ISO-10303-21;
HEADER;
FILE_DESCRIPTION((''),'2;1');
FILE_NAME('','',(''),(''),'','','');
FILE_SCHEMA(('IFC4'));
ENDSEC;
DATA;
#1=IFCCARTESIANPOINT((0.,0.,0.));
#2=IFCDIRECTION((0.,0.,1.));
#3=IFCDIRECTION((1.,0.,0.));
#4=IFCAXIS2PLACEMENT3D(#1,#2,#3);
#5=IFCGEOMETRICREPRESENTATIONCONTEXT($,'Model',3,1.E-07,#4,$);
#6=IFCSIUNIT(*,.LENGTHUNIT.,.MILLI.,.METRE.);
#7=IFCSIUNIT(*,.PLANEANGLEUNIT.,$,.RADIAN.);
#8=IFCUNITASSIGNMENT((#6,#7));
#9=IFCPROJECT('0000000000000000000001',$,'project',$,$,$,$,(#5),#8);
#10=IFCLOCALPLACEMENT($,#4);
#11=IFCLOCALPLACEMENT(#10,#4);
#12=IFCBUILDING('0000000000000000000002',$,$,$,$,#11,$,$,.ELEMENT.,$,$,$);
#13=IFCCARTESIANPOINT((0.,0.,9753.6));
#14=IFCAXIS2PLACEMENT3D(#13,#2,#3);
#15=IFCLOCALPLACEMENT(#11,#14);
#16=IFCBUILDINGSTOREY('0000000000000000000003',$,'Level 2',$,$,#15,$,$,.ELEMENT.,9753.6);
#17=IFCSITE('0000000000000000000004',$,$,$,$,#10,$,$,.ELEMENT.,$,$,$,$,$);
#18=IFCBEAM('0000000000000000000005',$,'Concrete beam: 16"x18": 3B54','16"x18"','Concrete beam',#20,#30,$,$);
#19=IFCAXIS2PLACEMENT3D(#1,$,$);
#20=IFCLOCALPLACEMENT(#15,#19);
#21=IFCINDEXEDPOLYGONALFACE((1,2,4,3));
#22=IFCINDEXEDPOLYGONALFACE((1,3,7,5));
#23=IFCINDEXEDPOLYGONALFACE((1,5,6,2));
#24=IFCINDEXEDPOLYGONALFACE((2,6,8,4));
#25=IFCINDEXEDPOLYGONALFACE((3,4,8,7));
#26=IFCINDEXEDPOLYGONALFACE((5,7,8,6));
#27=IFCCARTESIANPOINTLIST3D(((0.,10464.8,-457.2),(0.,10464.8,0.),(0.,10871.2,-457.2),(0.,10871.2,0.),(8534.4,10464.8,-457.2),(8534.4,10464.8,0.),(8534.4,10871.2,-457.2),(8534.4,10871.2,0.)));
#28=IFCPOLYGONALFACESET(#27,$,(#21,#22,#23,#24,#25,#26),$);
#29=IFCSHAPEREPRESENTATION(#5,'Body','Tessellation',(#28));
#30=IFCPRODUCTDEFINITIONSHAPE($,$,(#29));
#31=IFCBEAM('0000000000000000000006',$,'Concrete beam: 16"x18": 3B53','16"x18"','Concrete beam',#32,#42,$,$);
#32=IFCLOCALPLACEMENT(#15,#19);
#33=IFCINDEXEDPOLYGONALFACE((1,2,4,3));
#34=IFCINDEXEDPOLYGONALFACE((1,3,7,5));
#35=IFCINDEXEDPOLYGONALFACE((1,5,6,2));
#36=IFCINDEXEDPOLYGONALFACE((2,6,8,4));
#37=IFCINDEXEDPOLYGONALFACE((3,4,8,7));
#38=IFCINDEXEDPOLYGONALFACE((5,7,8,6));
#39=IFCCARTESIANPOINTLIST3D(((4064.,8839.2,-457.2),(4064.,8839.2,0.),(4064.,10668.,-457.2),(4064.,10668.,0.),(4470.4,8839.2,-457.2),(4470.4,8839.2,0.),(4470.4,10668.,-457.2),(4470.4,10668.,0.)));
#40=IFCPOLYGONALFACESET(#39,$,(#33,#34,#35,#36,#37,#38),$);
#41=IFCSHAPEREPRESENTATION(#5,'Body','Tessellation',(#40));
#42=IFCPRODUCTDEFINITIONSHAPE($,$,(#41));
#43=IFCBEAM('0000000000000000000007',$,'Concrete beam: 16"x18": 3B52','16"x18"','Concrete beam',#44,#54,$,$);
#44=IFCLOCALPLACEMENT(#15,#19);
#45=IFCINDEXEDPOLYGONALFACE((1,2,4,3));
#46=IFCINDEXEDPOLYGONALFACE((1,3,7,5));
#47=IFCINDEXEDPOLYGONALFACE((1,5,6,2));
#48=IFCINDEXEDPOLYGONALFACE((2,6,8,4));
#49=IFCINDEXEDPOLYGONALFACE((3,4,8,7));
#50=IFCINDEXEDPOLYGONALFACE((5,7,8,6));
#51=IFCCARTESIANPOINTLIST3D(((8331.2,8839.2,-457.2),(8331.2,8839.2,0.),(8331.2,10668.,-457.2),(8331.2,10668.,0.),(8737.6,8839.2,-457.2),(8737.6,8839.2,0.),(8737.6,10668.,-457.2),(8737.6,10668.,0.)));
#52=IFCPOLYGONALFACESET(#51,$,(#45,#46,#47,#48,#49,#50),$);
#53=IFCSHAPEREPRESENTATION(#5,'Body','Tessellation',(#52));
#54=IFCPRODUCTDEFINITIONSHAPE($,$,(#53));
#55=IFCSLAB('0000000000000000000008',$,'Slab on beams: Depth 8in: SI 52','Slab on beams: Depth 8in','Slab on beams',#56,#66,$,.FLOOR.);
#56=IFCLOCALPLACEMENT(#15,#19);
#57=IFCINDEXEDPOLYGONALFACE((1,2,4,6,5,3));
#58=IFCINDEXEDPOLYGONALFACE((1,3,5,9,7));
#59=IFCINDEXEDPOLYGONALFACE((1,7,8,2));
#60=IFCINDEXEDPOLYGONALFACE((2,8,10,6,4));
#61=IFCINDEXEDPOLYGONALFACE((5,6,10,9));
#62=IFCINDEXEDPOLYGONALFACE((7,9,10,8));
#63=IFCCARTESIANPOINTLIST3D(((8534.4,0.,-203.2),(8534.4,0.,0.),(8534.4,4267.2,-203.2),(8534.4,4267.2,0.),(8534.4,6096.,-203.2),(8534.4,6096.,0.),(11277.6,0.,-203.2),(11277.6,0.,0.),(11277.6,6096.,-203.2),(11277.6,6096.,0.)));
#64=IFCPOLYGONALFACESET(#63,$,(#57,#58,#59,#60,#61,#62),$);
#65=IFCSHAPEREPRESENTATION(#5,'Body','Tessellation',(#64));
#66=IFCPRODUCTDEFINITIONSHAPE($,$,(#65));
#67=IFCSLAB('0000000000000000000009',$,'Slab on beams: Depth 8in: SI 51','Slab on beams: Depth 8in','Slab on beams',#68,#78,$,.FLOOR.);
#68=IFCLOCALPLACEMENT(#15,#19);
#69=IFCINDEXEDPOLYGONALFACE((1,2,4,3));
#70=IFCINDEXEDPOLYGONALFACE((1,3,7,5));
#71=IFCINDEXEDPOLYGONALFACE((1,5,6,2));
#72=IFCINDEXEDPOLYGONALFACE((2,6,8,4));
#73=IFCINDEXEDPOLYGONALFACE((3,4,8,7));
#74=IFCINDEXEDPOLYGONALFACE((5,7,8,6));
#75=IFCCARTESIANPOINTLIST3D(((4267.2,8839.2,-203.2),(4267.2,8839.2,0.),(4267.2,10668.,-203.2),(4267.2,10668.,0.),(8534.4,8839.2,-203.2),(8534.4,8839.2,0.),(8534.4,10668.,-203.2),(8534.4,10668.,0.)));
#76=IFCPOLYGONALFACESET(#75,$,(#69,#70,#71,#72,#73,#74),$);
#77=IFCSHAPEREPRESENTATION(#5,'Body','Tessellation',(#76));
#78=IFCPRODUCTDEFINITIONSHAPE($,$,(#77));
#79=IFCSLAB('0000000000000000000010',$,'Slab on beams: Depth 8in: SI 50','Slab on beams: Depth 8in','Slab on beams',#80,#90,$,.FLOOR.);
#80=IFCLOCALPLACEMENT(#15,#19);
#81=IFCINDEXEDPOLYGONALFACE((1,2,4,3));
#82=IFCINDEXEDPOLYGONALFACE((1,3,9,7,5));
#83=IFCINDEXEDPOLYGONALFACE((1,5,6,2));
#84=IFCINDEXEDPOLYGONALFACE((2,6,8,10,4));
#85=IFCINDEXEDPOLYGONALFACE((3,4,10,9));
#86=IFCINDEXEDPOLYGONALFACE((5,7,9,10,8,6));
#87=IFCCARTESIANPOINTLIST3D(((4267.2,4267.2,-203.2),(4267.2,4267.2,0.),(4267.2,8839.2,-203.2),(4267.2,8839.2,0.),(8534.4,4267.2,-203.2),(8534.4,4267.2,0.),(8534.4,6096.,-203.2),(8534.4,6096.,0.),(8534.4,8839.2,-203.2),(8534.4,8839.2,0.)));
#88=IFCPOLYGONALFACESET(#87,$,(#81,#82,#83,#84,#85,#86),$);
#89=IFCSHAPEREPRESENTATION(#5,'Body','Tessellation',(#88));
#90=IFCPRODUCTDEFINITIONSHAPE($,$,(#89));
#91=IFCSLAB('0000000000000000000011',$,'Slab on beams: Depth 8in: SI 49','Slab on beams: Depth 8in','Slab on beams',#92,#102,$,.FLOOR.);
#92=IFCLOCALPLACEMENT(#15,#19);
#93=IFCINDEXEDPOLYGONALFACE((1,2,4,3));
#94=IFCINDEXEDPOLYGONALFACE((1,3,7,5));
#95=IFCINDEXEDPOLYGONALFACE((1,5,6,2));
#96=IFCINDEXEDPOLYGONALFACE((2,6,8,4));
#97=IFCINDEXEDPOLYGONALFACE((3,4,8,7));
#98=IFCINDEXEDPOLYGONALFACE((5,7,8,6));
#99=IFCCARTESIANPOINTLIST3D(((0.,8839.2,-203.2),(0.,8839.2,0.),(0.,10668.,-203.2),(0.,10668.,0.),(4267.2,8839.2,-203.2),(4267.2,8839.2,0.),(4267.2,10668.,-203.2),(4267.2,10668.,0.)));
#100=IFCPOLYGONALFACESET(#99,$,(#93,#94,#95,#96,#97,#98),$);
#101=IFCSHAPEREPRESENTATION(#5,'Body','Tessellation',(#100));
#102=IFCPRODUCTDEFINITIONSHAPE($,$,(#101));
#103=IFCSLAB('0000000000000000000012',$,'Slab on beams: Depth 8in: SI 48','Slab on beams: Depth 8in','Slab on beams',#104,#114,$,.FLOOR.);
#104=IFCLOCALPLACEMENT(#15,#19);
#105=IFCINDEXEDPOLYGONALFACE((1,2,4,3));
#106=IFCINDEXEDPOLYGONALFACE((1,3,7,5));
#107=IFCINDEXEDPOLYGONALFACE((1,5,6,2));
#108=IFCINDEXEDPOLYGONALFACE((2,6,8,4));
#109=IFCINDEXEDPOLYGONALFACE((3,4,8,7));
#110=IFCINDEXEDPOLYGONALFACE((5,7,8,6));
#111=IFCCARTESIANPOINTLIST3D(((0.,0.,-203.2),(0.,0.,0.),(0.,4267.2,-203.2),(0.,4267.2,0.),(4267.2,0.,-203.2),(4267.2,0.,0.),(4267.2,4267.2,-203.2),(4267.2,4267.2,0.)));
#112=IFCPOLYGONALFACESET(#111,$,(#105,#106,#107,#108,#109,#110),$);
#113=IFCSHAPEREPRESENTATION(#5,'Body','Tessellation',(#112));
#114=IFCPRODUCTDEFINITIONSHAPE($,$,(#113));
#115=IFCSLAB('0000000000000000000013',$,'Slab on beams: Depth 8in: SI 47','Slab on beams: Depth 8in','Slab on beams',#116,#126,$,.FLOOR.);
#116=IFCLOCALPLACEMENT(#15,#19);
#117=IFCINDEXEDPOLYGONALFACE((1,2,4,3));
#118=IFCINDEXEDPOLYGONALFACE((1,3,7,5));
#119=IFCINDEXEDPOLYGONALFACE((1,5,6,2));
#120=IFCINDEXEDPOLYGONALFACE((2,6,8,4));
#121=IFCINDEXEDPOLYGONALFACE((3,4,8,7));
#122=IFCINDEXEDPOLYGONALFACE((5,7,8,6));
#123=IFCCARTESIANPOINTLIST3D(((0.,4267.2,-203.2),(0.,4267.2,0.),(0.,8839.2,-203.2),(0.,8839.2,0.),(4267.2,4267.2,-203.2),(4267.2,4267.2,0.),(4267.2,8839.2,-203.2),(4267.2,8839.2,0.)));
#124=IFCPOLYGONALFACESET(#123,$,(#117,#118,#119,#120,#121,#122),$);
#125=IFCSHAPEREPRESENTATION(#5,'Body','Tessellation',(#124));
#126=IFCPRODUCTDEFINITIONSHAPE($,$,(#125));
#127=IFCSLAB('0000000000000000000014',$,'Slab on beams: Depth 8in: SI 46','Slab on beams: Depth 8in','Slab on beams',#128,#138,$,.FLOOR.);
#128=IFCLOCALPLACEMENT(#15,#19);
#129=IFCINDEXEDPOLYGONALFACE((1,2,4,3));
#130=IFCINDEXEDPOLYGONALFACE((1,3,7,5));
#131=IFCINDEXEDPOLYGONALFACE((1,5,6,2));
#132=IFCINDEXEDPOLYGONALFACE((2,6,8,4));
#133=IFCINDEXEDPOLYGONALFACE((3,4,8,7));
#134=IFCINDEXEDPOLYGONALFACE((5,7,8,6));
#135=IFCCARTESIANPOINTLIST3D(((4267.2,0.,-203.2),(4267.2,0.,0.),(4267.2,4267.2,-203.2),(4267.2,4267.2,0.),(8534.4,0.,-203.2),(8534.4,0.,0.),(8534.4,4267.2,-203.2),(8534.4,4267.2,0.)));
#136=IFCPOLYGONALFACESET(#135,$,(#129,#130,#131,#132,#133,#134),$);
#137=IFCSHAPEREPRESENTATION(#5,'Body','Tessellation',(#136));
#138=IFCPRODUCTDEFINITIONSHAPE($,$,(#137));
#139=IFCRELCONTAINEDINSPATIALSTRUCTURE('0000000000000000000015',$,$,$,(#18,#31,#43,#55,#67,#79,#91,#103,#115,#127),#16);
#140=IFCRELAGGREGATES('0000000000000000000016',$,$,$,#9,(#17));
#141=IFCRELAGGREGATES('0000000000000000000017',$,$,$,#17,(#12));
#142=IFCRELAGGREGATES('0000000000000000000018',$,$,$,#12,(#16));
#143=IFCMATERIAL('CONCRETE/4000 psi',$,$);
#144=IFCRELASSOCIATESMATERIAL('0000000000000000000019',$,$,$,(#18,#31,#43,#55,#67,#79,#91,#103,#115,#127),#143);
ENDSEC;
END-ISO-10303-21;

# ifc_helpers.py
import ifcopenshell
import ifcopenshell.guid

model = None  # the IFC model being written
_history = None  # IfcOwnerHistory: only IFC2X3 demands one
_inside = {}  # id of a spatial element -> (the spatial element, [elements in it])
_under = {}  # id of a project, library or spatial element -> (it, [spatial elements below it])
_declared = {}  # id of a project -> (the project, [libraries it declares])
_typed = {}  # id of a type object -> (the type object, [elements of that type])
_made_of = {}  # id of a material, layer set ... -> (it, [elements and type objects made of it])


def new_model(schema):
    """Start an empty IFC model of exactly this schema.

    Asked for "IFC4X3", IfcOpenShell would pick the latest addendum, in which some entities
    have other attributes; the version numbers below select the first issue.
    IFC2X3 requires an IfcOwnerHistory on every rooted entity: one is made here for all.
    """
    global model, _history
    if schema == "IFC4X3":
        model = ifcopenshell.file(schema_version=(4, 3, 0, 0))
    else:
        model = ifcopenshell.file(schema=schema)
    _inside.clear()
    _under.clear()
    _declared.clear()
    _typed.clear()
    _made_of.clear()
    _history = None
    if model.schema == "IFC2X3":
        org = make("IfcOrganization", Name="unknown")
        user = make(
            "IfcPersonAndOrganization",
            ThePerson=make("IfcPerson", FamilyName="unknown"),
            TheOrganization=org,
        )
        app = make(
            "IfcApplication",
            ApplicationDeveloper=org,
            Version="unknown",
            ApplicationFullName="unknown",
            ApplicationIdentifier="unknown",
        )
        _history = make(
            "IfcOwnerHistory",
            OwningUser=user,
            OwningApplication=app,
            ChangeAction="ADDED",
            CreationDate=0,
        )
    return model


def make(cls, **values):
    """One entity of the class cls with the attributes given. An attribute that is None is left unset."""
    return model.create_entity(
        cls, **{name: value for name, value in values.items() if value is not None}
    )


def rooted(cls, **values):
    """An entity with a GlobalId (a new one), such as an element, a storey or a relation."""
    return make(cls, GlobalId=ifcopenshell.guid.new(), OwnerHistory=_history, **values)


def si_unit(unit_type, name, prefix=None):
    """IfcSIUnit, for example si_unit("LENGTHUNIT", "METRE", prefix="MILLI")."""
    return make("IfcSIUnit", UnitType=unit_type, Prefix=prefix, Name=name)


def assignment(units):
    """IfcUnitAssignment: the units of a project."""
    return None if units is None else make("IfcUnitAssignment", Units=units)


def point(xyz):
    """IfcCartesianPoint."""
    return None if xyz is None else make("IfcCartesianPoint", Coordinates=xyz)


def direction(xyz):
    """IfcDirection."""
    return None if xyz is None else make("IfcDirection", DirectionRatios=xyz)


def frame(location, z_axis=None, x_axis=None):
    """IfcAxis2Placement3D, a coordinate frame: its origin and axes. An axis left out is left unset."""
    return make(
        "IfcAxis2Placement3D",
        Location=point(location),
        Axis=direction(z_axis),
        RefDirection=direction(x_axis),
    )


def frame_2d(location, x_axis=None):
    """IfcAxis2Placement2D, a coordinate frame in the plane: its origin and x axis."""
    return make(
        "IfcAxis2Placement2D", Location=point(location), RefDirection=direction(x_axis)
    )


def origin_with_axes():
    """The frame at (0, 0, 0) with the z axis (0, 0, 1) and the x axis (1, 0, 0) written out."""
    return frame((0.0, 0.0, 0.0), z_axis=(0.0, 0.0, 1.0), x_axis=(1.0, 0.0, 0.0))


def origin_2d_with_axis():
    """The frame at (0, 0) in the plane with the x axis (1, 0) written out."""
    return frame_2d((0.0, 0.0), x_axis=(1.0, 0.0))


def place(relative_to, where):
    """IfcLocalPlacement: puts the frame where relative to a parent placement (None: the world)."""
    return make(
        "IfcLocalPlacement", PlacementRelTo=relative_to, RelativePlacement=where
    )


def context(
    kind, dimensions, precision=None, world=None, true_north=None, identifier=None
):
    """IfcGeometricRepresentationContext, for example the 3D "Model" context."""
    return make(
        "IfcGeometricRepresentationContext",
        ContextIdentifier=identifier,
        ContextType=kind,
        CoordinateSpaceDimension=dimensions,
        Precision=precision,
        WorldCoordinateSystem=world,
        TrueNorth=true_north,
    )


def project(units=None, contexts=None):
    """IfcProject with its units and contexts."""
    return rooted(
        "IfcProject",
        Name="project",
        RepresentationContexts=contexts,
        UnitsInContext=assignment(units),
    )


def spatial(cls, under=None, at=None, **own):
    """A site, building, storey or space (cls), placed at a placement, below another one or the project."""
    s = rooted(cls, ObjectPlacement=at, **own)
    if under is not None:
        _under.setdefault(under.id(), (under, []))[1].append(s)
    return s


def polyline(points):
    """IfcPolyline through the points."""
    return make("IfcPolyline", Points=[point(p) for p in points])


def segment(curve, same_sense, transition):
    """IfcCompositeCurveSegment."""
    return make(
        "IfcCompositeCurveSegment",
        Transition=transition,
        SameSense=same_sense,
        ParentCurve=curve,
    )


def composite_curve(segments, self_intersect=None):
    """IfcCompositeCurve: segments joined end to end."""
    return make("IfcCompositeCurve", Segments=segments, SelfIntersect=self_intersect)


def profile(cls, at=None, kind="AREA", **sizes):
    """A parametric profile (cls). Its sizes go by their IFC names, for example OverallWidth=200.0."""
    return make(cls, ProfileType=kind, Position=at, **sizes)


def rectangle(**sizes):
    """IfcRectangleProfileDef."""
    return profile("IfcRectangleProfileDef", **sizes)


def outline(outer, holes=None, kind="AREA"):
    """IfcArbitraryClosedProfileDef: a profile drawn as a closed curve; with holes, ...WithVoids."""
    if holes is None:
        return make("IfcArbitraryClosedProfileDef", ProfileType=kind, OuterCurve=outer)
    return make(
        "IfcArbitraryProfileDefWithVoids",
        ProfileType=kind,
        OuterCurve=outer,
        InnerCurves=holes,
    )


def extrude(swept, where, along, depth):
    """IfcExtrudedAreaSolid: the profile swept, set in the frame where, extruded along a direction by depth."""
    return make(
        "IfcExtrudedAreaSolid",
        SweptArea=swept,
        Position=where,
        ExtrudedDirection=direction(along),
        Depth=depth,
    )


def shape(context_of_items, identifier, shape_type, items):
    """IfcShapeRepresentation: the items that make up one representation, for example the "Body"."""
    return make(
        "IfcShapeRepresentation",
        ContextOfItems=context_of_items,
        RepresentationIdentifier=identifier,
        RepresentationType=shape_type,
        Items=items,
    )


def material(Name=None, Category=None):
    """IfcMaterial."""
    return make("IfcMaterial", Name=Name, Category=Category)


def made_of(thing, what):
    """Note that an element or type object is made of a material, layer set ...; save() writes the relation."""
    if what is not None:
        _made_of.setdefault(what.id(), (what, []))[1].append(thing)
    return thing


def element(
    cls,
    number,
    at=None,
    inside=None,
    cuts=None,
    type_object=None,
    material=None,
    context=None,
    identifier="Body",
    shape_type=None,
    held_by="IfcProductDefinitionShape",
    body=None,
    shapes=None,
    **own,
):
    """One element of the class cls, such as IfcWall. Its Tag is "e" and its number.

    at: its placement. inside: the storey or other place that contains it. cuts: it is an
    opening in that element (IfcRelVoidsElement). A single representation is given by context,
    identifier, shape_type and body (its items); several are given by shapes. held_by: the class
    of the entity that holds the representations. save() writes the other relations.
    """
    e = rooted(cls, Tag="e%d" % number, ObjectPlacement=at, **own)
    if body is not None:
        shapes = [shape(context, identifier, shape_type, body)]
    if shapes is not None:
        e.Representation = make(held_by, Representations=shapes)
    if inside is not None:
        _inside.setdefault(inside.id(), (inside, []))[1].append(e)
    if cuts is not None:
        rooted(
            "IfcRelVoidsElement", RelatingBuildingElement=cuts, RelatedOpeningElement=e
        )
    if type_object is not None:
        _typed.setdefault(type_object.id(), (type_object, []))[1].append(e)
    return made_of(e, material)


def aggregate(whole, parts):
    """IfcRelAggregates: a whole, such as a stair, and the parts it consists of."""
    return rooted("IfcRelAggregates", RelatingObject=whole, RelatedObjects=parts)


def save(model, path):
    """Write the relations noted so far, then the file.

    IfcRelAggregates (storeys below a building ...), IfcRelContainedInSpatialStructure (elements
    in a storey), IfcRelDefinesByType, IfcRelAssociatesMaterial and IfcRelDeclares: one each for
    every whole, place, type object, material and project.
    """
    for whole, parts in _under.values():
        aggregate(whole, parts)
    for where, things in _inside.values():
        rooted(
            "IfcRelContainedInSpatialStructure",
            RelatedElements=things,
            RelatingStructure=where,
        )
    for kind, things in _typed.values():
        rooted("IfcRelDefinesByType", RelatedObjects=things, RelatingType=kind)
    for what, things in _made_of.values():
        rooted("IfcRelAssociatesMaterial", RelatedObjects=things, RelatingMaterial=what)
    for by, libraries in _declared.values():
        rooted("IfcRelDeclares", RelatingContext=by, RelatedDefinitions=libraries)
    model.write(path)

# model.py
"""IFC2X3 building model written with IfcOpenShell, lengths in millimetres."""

from ifc_helpers import new_model, si_unit, frame, origin_with_axes, origin_2d_with_axis, place, context, project, spatial, polyline, segment, composite_curve, rectangle, outline, extrude, material, element, save


model = new_model("IFC2X3")

# Units and contexts
model_context = context("Model", 3, precision=1e-07, world=origin_with_axes())
ifc_project = project(units=[si_unit("LENGTHUNIT", "METRE", prefix="MILLI"), si_unit("PLANEANGLEUNIT", "RADIAN")], contexts=[model_context])

# Site, building, storey
site_placement = place(None, origin_with_axes())
site = spatial("IfcSite", under=ifc_project, at=site_placement, CompositionType="ELEMENT")
building_placement = place(site_placement, origin_with_axes())
building = spatial("IfcBuilding", under=site, at=building_placement, CompositionType="ELEMENT")
storey_placement = place(building_placement, frame((0.0, 0.0, 9753.6), z_axis=(0.0, 0.0, 1.0), x_axis=(1.0, 0.0, 0.0)))
storey = spatial("IfcBuildingStorey", under=building, at=storey_placement, Name="Level 2", CompositionType="ELEMENT", Elevation=9753.6)

# Beams
ifc_material = material(Name="CONCRETE/4000 psi")
beam_1_placement = place(building_placement, frame((0.0, 10668.0, 9753.6), z_axis=(0.0, 0.0, 1.0), x_axis=(1.0, 0.0, 0.0)))
element("IfcBeam", 1, at=beam_1_placement, inside=storey, material=ifc_material, Name="Concrete beam: 16\"x18\": 3B54", Description="16\"x18\"", ObjectType="Concrete beam", context=model_context, shape_type="SweptSolid", body=[
    extrude(rectangle(XDim=406.4, YDim=457.2, at=origin_2d_with_axis()), frame((8534.4, 0.0, -228.6), z_axis=(-1.0, 0.0, 0.0), x_axis=(0.0, -1.0, 0.0)), (0.0, 0.0, 1.0), 8534.4),
])
for number, where, z_axis, x_axis, name in (
    (2, (4267.2, 10668.0, 9753.6), (0.0, 0.0, 1.0), (0.0, -1.0, 0.0), "Concrete beam: 16\"x18\": 3B53"),
    (3, (8534.4, 10668.0, 9753.6), (0.0, 0.0, 1.0), (0.0, -1.0, 0.0), "Concrete beam: 16\"x18\": 3B52"),
):
    element("IfcBeam", number, at=place(building_placement, frame(where, z_axis=z_axis, x_axis=x_axis)), inside=storey, material=ifc_material, Name=name, Description="16\"x18\"", ObjectType="Concrete beam", context=model_context, shape_type="SweptSolid", body=[
        extrude(rectangle(XDim=406.4, YDim=457.2, at=origin_2d_with_axis()), frame((1828.8, 0.0, -228.6), z_axis=(-1.0, 0.0, 0.0), x_axis=(0.0, -1.0, 0.0)), (0.0, 0.0, 1.0), 1828.8),
    ])

# Slabs
slab_1_placement = place(building_placement, frame((0.0, 0.0, 9753.6), z_axis=(0.0, 0.0, 1.0), x_axis=(1.0, 0.0, 0.0)))
element("IfcSlab", 4, at=slab_1_placement, inside=storey, material=ifc_material, Name="Slab on beams: Depth 8in: SI 52", Description="Slab on beams: Depth 8in", ObjectType="Slab on beams", PredefinedType="FLOOR", context=model_context, shape_type="SweptSolid", body=[
    extrude(outline(composite_curve([segment(polyline([(8534.4, 6096.0), (8534.4, 4267.2)]), True, "CONTINUOUS"), segment(polyline([(8534.4, 4267.2), (8534.4, 0.0)]), True, "CONTINUOUS"), segment(polyline([(8534.4, 0.0), (11277.6, 0.0)]), True, "CONTINUOUS"), segment(polyline([(11277.6, 0.0), (11277.6, 6096.0)]), True, "CONTINUOUS"), segment(polyline([(11277.6, 6096.0), (8534.4, 6096.0)]), True, "CONTINUOUS")], self_intersect=False)), frame((0.0, 0.0, -203.2), z_axis=(0.0, 0.0, 1.0), x_axis=(1.0, 0.0, 0.0)), (0.0, 0.0, 1.0), 203.2),
])
slab_2_placement = place(building_placement, frame((0.0, 0.0, 9753.6), z_axis=(0.0, 0.0, 1.0), x_axis=(1.0, 0.0, 0.0)))
element("IfcSlab", 5, at=slab_2_placement, inside=storey, material=ifc_material, Name="Slab on beams: Depth 8in: SI 51", Description="Slab on beams: Depth 8in", ObjectType="Slab on beams", PredefinedType="FLOOR", context=model_context, shape_type="SweptSolid", body=[
    extrude(outline(composite_curve([segment(polyline([(4267.2, 10668.0), (4267.2, 8839.2)]), True, "CONTINUOUS"), segment(polyline([(4267.2, 8839.2), (8534.4, 8839.2)]), True, "CONTINUOUS"), segment(polyline([(8534.4, 8839.2), (8534.4, 10668.0)]), True, "CONTINUOUS"), segment(polyline([(8534.4, 10668.0), (4267.2, 10668.0)]), True, "CONTINUOUS")], self_intersect=False)), frame((0.0, 0.0, -203.2), z_axis=(0.0, 0.0, 1.0), x_axis=(1.0, 0.0, 0.0)), (0.0, 0.0, 1.0), 203.2),
])
slab_3_placement = place(building_placement, frame((0.0, 0.0, 9753.6), z_axis=(0.0, 0.0, 1.0), x_axis=(1.0, 0.0, 0.0)))
element("IfcSlab", 6, at=slab_3_placement, inside=storey, material=ifc_material, Name="Slab on beams: Depth 8in: SI 50", Description="Slab on beams: Depth 8in", ObjectType="Slab on beams", PredefinedType="FLOOR", context=model_context, shape_type="SweptSolid", body=[
    extrude(outline(composite_curve([segment(polyline([(4267.2, 8839.2), (4267.2, 4267.2)]), True, "CONTINUOUS"), segment(polyline([(4267.2, 4267.2), (8534.4, 4267.2)]), True, "CONTINUOUS"), segment(polyline([(8534.4, 4267.2), (8534.4, 6096.0)]), True, "CONTINUOUS"), segment(polyline([(8534.4, 6096.0), (8534.4, 8839.2)]), True, "CONTINUOUS"), segment(polyline([(8534.4, 8839.2), (4267.2, 8839.2)]), True, "CONTINUOUS")], self_intersect=False)), frame((0.0, 0.0, -203.2), z_axis=(0.0, 0.0, 1.0), x_axis=(1.0, 0.0, 0.0)), (0.0, 0.0, 1.0), 203.2),
])
slab_4_placement = place(building_placement, frame((0.0, 0.0, 9753.6), z_axis=(0.0, 0.0, 1.0), x_axis=(1.0, 0.0, 0.0)))
element("IfcSlab", 7, at=slab_4_placement, inside=storey, material=ifc_material, Name="Slab on beams: Depth 8in: SI 49", Description="Slab on beams: Depth 8in", ObjectType="Slab on beams", PredefinedType="FLOOR", context=model_context, shape_type="SweptSolid", body=[
    extrude(outline(composite_curve([segment(polyline([(0.0, 10668.0), (0.0, 8839.2)]), True, "CONTINUOUS"), segment(polyline([(0.0, 8839.2), (4267.2, 8839.2)]), True, "CONTINUOUS"), segment(polyline([(4267.2, 8839.2), (4267.2, 10668.0)]), True, "CONTINUOUS"), segment(polyline([(4267.2, 10668.0), (0.0, 10668.0)]), True, "CONTINUOUS")], self_intersect=False)), frame((0.0, 0.0, -203.2), z_axis=(0.0, 0.0, 1.0), x_axis=(1.0, 0.0, 0.0)), (0.0, 0.0, 1.0), 203.2),
])
slab_5_placement = place(building_placement, frame((0.0, 0.0, 9753.6), z_axis=(0.0, 0.0, 1.0), x_axis=(1.0, 0.0, 0.0)))
element("IfcSlab", 8, at=slab_5_placement, inside=storey, material=ifc_material, Name="Slab on beams: Depth 8in: SI 48", Description="Slab on beams: Depth 8in", ObjectType="Slab on beams", PredefinedType="FLOOR", context=model_context, shape_type="SweptSolid", body=[
    extrude(outline(composite_curve([segment(polyline([(0.0, 4267.2), (0.0, 0.0)]), True, "CONTINUOUS"), segment(polyline([(0.0, 0.0), (4267.2, 0.0)]), True, "CONTINUOUS"), segment(polyline([(4267.2, 0.0), (4267.2, 4267.2)]), True, "CONTINUOUS"), segment(polyline([(4267.2, 4267.2), (0.0, 4267.2)]), True, "CONTINUOUS")], self_intersect=False)), frame((0.0, 0.0, -203.2), z_axis=(0.0, 0.0, 1.0), x_axis=(1.0, 0.0, 0.0)), (0.0, 0.0, 1.0), 203.2),
])
slab_6_placement = place(building_placement, frame((0.0, 0.0, 9753.6), z_axis=(0.0, 0.0, 1.0), x_axis=(1.0, 0.0, 0.0)))
element("IfcSlab", 9, at=slab_6_placement, inside=storey, material=ifc_material, Name="Slab on beams: Depth 8in: SI 47", Description="Slab on beams: Depth 8in", ObjectType="Slab on beams", PredefinedType="FLOOR", context=model_context, shape_type="SweptSolid", body=[
    extrude(outline(composite_curve([segment(polyline([(0.0, 8839.2), (0.0, 4267.2)]), True, "CONTINUOUS"), segment(polyline([(0.0, 4267.2), (4267.2, 4267.2)]), True, "CONTINUOUS"), segment(polyline([(4267.2, 4267.2), (4267.2, 8839.2)]), True, "CONTINUOUS"), segment(polyline([(4267.2, 8839.2), (0.0, 8839.2)]), True, "CONTINUOUS")], self_intersect=False)), frame((0.0, 0.0, -203.2), z_axis=(0.0, 0.0, 1.0), x_axis=(1.0, 0.0, 0.0)), (0.0, 0.0, 1.0), 203.2),
])
slab_7_placement = place(building_placement, frame((0.0, 0.0, 9753.6), z_axis=(0.0, 0.0, 1.0), x_axis=(1.0, 0.0, 0.0)))
element("IfcSlab", 10, at=slab_7_placement, inside=storey, material=ifc_material, Name="Slab on beams: Depth 8in: SI 46", Description="Slab on beams: Depth 8in", ObjectType="Slab on beams", PredefinedType="FLOOR", context=model_context, shape_type="SweptSolid", body=[
    extrude(outline(composite_curve([segment(polyline([(4267.2, 4267.2), (4267.2, 0.0)]), True, "CONTINUOUS"), segment(polyline([(4267.2, 0.0), (8534.4, 0.0)]), True, "CONTINUOUS"), segment(polyline([(8534.4, 0.0), (8534.4, 4267.2)]), True, "CONTINUOUS"), segment(polyline([(8534.4, 4267.2), (4267.2, 4267.2)]), True, "CONTINUOUS")], self_intersect=False)), frame((0.0, 0.0, -203.2), z_axis=(0.0, 0.0, 1.0), x_axis=(1.0, 0.0, 0.0)), (0.0, 0.0, 1.0), 203.2),
])

save(model, "model.ifc")
